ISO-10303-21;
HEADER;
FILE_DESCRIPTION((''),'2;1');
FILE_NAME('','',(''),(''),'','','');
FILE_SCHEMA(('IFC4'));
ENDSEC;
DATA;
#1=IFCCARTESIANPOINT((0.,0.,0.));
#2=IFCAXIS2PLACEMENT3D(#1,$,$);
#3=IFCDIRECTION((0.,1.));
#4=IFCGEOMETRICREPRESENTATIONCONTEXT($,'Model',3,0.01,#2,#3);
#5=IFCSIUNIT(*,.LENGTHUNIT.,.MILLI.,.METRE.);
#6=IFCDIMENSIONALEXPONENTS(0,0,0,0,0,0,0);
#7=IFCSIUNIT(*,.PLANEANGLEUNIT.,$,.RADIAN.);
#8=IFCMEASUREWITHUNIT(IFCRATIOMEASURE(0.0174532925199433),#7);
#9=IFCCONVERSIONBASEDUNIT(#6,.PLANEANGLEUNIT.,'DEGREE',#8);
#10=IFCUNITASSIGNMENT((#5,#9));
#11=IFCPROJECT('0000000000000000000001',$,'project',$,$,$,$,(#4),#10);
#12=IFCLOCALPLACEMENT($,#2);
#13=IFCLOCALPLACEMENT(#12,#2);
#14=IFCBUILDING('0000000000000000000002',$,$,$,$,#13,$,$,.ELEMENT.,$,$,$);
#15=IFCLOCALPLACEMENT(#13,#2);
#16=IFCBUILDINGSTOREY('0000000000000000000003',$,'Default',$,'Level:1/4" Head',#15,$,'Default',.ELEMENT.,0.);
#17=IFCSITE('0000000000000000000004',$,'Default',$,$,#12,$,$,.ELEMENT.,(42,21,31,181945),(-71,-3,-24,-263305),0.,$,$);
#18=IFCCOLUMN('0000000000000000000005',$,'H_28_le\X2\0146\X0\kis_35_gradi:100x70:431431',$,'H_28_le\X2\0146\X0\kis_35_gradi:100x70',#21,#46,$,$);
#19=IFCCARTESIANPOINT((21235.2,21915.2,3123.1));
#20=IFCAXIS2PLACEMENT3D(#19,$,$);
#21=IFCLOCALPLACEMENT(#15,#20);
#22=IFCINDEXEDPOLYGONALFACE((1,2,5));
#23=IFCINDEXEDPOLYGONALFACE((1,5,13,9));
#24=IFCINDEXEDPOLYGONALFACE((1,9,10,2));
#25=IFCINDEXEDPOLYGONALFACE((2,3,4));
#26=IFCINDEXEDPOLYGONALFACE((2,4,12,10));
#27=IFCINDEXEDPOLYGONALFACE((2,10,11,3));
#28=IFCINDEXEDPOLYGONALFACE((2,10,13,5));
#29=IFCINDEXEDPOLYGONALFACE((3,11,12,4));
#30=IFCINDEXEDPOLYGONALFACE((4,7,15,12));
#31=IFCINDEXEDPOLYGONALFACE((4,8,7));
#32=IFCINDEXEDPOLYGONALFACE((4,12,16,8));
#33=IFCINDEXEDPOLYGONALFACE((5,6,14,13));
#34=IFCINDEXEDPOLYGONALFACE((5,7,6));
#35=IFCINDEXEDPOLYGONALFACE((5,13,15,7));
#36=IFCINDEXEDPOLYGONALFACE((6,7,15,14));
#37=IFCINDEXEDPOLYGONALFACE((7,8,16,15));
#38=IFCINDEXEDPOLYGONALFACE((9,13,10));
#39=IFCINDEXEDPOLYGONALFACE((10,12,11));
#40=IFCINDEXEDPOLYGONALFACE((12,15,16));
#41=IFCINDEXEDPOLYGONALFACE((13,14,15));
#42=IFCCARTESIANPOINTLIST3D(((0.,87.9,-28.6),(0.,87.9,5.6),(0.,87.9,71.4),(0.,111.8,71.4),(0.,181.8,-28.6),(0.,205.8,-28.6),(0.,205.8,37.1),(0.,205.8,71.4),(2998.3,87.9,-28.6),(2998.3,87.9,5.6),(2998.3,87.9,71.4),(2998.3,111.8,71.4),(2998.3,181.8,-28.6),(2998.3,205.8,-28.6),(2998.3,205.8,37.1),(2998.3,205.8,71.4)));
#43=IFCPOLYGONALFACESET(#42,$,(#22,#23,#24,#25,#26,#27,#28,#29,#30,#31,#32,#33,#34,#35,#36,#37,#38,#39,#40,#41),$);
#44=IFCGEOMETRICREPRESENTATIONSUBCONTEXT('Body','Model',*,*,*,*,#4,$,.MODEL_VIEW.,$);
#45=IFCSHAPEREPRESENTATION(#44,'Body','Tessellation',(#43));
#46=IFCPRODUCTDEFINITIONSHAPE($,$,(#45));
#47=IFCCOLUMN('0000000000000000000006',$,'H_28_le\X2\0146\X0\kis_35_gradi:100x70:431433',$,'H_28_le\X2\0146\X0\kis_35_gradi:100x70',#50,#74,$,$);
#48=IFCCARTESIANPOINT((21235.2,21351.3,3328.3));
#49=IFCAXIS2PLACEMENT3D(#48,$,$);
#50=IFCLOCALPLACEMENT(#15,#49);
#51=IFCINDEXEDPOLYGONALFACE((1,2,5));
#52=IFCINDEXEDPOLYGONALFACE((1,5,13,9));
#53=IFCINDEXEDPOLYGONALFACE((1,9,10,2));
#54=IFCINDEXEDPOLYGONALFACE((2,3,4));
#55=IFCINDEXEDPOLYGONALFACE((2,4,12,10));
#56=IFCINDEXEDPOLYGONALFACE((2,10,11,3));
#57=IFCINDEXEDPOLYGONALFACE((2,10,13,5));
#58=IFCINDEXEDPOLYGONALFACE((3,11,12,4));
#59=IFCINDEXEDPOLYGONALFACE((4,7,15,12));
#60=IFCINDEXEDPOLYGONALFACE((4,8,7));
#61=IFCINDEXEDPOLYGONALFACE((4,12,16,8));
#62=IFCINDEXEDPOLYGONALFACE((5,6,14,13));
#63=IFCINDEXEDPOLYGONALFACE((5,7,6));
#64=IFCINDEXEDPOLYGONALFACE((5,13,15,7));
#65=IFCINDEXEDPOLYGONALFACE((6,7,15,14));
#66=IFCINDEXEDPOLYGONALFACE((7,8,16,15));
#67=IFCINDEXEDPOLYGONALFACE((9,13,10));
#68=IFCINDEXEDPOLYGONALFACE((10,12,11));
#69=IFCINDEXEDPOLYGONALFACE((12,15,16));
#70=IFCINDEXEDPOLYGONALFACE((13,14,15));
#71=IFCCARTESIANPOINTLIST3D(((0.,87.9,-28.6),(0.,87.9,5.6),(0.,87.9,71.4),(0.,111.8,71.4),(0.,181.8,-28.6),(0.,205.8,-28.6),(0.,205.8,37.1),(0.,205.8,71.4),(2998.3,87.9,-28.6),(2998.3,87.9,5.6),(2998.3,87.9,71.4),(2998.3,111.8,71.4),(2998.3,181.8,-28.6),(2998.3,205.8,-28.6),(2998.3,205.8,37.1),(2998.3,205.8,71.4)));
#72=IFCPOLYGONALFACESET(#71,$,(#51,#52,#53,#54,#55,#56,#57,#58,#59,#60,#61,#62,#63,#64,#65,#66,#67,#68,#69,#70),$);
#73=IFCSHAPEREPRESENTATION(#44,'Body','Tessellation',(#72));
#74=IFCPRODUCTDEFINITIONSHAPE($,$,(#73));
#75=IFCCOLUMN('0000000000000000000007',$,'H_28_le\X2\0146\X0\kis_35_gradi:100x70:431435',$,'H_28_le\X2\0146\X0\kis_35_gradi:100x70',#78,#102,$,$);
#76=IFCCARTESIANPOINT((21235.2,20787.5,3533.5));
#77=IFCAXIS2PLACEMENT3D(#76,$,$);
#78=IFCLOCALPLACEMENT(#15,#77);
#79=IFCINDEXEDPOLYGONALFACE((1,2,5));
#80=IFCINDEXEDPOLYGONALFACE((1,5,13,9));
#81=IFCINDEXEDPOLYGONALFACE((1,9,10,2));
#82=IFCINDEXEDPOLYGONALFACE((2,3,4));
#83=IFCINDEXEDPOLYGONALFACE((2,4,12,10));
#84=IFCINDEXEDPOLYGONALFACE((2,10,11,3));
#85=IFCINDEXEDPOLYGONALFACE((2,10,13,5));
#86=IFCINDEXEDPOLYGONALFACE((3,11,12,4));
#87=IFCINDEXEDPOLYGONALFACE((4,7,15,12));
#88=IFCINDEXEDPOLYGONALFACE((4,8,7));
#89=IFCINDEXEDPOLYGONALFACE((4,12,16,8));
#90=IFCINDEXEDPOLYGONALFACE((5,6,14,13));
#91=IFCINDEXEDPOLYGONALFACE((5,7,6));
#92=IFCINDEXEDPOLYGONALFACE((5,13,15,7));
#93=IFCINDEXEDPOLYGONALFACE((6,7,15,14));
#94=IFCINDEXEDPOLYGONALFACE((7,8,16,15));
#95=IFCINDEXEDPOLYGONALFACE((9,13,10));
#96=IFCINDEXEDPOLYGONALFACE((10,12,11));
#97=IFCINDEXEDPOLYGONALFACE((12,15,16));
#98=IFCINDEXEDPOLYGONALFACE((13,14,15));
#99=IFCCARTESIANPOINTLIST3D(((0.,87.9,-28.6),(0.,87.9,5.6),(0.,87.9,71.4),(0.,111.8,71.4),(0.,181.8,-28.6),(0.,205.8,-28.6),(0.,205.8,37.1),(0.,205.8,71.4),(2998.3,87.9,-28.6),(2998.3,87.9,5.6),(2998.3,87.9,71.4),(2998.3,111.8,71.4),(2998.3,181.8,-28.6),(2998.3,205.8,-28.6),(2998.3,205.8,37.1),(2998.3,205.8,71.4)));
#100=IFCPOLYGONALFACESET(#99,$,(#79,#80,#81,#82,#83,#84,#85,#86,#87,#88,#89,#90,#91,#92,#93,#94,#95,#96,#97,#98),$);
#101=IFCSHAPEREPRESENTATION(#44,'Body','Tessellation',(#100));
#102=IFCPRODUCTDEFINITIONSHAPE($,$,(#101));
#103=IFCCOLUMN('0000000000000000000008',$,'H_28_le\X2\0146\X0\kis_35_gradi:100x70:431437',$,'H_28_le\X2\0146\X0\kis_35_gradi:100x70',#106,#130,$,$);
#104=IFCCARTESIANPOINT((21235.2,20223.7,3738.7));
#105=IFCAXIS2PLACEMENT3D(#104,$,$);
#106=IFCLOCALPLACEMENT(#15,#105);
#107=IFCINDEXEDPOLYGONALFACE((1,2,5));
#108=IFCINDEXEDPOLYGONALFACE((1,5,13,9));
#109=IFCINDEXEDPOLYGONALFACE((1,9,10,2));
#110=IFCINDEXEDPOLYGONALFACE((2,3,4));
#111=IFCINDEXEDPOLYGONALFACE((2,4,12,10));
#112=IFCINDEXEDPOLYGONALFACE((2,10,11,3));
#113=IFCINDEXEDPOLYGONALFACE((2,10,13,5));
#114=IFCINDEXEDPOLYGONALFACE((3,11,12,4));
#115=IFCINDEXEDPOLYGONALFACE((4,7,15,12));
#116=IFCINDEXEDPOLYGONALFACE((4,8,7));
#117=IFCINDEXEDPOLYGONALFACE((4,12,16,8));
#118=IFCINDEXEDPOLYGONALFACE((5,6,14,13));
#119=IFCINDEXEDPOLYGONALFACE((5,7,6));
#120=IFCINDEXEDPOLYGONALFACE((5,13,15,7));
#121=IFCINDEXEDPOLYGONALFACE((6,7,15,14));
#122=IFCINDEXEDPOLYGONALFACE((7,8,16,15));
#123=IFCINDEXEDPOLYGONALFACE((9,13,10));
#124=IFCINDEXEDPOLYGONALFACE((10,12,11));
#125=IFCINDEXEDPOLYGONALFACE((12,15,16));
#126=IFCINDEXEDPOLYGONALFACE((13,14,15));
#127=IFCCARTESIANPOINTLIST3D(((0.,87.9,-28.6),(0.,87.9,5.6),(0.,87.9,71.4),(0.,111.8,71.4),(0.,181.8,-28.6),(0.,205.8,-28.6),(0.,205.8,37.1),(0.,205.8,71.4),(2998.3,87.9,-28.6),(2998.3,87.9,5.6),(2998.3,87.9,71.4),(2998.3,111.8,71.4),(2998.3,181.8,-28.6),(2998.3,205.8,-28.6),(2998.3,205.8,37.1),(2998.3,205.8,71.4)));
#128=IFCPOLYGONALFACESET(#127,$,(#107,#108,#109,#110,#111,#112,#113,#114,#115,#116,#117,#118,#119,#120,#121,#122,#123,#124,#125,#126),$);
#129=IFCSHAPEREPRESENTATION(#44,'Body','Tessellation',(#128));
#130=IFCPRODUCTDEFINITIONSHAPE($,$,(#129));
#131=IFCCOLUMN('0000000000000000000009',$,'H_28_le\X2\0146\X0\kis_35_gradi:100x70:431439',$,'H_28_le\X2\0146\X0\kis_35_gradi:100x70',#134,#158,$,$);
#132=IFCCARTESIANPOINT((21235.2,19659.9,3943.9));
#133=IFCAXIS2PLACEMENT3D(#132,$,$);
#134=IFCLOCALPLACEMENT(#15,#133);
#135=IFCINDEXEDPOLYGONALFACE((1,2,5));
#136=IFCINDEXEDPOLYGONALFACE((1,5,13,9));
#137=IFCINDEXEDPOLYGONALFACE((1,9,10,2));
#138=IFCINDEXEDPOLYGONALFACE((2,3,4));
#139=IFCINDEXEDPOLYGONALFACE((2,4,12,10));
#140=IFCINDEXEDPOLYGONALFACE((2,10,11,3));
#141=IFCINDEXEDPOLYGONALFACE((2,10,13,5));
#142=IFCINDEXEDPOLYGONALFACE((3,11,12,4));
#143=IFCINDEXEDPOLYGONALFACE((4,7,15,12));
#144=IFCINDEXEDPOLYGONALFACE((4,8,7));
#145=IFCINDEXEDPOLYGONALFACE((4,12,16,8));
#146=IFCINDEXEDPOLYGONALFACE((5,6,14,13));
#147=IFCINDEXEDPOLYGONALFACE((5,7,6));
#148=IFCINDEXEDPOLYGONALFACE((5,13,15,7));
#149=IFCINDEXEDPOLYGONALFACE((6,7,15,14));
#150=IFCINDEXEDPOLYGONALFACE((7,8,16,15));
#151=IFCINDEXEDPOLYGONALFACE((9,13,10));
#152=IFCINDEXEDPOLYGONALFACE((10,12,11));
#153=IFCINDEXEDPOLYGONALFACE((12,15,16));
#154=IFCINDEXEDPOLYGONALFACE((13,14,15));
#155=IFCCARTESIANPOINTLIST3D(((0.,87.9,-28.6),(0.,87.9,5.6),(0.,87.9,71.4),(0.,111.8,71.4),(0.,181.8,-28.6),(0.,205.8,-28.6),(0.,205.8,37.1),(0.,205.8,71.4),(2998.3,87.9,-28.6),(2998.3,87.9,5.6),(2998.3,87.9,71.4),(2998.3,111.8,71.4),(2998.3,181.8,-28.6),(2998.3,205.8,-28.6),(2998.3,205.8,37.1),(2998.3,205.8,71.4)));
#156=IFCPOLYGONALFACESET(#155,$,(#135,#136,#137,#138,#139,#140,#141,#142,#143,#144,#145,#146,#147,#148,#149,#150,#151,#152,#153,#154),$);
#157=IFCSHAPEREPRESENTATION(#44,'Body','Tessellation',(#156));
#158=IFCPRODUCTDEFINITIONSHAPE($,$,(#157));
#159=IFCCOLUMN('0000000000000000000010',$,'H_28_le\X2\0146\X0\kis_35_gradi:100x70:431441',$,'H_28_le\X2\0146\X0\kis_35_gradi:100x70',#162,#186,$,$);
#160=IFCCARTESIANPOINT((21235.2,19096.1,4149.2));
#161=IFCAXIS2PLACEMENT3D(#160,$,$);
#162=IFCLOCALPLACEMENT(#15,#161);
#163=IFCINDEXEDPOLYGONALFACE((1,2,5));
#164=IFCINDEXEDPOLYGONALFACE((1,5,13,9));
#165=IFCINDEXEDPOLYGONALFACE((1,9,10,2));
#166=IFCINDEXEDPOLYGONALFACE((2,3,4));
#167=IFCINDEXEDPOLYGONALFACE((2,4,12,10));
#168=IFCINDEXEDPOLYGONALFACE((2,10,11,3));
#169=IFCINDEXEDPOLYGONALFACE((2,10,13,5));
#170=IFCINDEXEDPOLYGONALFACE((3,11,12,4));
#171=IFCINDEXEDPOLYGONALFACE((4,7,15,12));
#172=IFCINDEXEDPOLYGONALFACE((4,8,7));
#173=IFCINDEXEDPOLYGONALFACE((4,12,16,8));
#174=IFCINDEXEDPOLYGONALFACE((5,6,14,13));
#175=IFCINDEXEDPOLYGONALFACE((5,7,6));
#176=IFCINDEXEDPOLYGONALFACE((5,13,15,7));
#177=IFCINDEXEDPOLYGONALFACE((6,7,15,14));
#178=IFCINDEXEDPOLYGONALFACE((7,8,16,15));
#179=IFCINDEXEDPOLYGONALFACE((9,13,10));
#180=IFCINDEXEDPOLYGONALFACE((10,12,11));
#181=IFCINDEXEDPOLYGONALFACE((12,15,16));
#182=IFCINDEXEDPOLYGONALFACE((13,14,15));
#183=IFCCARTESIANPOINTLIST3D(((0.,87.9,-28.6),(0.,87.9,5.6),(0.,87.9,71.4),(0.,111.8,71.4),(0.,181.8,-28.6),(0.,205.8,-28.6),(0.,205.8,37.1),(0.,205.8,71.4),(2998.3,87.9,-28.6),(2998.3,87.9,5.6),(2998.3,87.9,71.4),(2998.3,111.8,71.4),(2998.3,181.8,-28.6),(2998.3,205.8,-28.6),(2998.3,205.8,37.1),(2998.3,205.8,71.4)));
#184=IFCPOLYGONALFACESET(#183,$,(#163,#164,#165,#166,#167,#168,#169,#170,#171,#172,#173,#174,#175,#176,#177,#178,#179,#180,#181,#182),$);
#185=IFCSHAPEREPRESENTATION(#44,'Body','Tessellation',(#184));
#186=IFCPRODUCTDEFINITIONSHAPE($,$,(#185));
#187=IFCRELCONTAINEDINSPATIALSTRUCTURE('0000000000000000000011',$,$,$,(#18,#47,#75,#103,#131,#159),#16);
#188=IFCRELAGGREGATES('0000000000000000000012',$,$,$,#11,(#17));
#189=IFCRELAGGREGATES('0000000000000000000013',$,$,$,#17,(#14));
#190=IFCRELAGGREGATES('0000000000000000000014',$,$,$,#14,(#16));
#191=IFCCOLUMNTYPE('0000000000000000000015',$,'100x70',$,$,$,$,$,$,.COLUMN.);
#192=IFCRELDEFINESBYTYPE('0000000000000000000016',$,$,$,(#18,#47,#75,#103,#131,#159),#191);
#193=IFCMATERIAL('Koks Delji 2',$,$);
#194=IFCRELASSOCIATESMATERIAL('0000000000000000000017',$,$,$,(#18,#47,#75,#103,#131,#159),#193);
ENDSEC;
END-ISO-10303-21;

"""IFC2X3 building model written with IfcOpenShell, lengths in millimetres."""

from ifc_helpers import new_model, entity, si_unit, converted_unit, direction, frame, frame_2d, origin, place, context, subcontext, project, spatial, rectangle, extrude, boolean, source, transform, mapped, material, type_object, type_shapes, element, save


model = new_model("IFC2X3")

# Units and contexts
model_context = context("Model", 3, precision=0.01, world=origin(), true_north=direction((0.0, 1.0)))
body_context = subcontext(model_context, "Body", "Model", "MODEL_VIEW")
ifc_project = project(units=[si_unit("LENGTHUNIT", "METRE", prefix="MILLI"), converted_unit("PLANEANGLEUNIT", "DEGREE", entity("IfcRatioMeasure", 0.0174532925199433), si_unit("PLANEANGLEUNIT", "RADIAN"), dimensions=[0, 0, 0, 0, 0, 0, 0])], contexts=[model_context])

# Site, building, storey
site_placement = place(None, origin())
site = spatial("IfcSite", under=ifc_project, at=site_placement, Name="Default", CompositionType="ELEMENT", RefLatitude=(42, 21, 31, 181945), RefLongitude=(-71, -3, -24, -263305), RefElevation=0.0)
building_placement = place(site_placement, origin())
building = spatial("IfcBuilding", under=site, at=building_placement, CompositionType="ELEMENT")
storey_placement = place(building_placement, origin())
storey = spatial("IfcBuildingStorey", under=building, at=storey_placement, Name="Default", ObjectType="Level:1/4\" Head", LongName="Default", CompositionType="ELEMENT", Elevation=0.0)

# Columns
ifc_material_1 = material(Name="Koks Delji 2")
column_type = type_object("IfcColumnType", Name="100x70", PredefinedType="COLUMN")
shared_shape_1 = source(origin(), body_context, "Body", "CSG", [
    boolean("DIFFERENCE", extrude(rectangle(XDim=2998.3, YDim=117.9, at=frame_2d((0.0, 0.0), x_axis=(1.0, 0.0))), frame((1499.1, 146.8, -28.6)), (0.0, 0.0, 1.0), 100.0), extrude(rectangle(XDim=70.0, YDim=100.0, at=frame_2d((0.0, 0.0), x_axis=(0.0, 1.0))), frame((2998.3, 146.8, 21.4), z_axis=(1.0, 0.0, 0.0), x_axis=(0.0, 0.939693, -0.34202)), (0.0, 0.0, -1.0), 2998.3)),
])
type_shapes(column_type, [shared_shape_1])
for number, where, name in (
    (1, (21235.2, 21915.2, 3123.1), "H_28_leņkis_35_gradi:100x70:431431"),
    (2, (21235.2, 21351.3, 3328.3), "H_28_leņkis_35_gradi:100x70:431433"),
    (3, (21235.2, 20787.5, 3533.5), "H_28_leņkis_35_gradi:100x70:431435"),
    (4, (21235.2, 20223.7, 3738.7), "H_28_leņkis_35_gradi:100x70:431437"),
    (5, (21235.2, 19659.9, 3943.9), "H_28_leņkis_35_gradi:100x70:431439"),
    (6, (21235.2, 19096.1, 4149.2), "H_28_leņkis_35_gradi:100x70:431441"),
):
    element("IfcColumn", number, at=place(storey_placement, frame(where)), inside=storey, type_object=column_type, material=ifc_material_1, Name=name, ObjectType="H_28_leņkis_35_gradi:100x70", context=body_context, shape_type="MappedRepresentation", body=[
        mapped(shared_shape_1, transform((0.0, 0.0, 0.0), scale=1.0)),
    ])

save(model, "model.ifc")
